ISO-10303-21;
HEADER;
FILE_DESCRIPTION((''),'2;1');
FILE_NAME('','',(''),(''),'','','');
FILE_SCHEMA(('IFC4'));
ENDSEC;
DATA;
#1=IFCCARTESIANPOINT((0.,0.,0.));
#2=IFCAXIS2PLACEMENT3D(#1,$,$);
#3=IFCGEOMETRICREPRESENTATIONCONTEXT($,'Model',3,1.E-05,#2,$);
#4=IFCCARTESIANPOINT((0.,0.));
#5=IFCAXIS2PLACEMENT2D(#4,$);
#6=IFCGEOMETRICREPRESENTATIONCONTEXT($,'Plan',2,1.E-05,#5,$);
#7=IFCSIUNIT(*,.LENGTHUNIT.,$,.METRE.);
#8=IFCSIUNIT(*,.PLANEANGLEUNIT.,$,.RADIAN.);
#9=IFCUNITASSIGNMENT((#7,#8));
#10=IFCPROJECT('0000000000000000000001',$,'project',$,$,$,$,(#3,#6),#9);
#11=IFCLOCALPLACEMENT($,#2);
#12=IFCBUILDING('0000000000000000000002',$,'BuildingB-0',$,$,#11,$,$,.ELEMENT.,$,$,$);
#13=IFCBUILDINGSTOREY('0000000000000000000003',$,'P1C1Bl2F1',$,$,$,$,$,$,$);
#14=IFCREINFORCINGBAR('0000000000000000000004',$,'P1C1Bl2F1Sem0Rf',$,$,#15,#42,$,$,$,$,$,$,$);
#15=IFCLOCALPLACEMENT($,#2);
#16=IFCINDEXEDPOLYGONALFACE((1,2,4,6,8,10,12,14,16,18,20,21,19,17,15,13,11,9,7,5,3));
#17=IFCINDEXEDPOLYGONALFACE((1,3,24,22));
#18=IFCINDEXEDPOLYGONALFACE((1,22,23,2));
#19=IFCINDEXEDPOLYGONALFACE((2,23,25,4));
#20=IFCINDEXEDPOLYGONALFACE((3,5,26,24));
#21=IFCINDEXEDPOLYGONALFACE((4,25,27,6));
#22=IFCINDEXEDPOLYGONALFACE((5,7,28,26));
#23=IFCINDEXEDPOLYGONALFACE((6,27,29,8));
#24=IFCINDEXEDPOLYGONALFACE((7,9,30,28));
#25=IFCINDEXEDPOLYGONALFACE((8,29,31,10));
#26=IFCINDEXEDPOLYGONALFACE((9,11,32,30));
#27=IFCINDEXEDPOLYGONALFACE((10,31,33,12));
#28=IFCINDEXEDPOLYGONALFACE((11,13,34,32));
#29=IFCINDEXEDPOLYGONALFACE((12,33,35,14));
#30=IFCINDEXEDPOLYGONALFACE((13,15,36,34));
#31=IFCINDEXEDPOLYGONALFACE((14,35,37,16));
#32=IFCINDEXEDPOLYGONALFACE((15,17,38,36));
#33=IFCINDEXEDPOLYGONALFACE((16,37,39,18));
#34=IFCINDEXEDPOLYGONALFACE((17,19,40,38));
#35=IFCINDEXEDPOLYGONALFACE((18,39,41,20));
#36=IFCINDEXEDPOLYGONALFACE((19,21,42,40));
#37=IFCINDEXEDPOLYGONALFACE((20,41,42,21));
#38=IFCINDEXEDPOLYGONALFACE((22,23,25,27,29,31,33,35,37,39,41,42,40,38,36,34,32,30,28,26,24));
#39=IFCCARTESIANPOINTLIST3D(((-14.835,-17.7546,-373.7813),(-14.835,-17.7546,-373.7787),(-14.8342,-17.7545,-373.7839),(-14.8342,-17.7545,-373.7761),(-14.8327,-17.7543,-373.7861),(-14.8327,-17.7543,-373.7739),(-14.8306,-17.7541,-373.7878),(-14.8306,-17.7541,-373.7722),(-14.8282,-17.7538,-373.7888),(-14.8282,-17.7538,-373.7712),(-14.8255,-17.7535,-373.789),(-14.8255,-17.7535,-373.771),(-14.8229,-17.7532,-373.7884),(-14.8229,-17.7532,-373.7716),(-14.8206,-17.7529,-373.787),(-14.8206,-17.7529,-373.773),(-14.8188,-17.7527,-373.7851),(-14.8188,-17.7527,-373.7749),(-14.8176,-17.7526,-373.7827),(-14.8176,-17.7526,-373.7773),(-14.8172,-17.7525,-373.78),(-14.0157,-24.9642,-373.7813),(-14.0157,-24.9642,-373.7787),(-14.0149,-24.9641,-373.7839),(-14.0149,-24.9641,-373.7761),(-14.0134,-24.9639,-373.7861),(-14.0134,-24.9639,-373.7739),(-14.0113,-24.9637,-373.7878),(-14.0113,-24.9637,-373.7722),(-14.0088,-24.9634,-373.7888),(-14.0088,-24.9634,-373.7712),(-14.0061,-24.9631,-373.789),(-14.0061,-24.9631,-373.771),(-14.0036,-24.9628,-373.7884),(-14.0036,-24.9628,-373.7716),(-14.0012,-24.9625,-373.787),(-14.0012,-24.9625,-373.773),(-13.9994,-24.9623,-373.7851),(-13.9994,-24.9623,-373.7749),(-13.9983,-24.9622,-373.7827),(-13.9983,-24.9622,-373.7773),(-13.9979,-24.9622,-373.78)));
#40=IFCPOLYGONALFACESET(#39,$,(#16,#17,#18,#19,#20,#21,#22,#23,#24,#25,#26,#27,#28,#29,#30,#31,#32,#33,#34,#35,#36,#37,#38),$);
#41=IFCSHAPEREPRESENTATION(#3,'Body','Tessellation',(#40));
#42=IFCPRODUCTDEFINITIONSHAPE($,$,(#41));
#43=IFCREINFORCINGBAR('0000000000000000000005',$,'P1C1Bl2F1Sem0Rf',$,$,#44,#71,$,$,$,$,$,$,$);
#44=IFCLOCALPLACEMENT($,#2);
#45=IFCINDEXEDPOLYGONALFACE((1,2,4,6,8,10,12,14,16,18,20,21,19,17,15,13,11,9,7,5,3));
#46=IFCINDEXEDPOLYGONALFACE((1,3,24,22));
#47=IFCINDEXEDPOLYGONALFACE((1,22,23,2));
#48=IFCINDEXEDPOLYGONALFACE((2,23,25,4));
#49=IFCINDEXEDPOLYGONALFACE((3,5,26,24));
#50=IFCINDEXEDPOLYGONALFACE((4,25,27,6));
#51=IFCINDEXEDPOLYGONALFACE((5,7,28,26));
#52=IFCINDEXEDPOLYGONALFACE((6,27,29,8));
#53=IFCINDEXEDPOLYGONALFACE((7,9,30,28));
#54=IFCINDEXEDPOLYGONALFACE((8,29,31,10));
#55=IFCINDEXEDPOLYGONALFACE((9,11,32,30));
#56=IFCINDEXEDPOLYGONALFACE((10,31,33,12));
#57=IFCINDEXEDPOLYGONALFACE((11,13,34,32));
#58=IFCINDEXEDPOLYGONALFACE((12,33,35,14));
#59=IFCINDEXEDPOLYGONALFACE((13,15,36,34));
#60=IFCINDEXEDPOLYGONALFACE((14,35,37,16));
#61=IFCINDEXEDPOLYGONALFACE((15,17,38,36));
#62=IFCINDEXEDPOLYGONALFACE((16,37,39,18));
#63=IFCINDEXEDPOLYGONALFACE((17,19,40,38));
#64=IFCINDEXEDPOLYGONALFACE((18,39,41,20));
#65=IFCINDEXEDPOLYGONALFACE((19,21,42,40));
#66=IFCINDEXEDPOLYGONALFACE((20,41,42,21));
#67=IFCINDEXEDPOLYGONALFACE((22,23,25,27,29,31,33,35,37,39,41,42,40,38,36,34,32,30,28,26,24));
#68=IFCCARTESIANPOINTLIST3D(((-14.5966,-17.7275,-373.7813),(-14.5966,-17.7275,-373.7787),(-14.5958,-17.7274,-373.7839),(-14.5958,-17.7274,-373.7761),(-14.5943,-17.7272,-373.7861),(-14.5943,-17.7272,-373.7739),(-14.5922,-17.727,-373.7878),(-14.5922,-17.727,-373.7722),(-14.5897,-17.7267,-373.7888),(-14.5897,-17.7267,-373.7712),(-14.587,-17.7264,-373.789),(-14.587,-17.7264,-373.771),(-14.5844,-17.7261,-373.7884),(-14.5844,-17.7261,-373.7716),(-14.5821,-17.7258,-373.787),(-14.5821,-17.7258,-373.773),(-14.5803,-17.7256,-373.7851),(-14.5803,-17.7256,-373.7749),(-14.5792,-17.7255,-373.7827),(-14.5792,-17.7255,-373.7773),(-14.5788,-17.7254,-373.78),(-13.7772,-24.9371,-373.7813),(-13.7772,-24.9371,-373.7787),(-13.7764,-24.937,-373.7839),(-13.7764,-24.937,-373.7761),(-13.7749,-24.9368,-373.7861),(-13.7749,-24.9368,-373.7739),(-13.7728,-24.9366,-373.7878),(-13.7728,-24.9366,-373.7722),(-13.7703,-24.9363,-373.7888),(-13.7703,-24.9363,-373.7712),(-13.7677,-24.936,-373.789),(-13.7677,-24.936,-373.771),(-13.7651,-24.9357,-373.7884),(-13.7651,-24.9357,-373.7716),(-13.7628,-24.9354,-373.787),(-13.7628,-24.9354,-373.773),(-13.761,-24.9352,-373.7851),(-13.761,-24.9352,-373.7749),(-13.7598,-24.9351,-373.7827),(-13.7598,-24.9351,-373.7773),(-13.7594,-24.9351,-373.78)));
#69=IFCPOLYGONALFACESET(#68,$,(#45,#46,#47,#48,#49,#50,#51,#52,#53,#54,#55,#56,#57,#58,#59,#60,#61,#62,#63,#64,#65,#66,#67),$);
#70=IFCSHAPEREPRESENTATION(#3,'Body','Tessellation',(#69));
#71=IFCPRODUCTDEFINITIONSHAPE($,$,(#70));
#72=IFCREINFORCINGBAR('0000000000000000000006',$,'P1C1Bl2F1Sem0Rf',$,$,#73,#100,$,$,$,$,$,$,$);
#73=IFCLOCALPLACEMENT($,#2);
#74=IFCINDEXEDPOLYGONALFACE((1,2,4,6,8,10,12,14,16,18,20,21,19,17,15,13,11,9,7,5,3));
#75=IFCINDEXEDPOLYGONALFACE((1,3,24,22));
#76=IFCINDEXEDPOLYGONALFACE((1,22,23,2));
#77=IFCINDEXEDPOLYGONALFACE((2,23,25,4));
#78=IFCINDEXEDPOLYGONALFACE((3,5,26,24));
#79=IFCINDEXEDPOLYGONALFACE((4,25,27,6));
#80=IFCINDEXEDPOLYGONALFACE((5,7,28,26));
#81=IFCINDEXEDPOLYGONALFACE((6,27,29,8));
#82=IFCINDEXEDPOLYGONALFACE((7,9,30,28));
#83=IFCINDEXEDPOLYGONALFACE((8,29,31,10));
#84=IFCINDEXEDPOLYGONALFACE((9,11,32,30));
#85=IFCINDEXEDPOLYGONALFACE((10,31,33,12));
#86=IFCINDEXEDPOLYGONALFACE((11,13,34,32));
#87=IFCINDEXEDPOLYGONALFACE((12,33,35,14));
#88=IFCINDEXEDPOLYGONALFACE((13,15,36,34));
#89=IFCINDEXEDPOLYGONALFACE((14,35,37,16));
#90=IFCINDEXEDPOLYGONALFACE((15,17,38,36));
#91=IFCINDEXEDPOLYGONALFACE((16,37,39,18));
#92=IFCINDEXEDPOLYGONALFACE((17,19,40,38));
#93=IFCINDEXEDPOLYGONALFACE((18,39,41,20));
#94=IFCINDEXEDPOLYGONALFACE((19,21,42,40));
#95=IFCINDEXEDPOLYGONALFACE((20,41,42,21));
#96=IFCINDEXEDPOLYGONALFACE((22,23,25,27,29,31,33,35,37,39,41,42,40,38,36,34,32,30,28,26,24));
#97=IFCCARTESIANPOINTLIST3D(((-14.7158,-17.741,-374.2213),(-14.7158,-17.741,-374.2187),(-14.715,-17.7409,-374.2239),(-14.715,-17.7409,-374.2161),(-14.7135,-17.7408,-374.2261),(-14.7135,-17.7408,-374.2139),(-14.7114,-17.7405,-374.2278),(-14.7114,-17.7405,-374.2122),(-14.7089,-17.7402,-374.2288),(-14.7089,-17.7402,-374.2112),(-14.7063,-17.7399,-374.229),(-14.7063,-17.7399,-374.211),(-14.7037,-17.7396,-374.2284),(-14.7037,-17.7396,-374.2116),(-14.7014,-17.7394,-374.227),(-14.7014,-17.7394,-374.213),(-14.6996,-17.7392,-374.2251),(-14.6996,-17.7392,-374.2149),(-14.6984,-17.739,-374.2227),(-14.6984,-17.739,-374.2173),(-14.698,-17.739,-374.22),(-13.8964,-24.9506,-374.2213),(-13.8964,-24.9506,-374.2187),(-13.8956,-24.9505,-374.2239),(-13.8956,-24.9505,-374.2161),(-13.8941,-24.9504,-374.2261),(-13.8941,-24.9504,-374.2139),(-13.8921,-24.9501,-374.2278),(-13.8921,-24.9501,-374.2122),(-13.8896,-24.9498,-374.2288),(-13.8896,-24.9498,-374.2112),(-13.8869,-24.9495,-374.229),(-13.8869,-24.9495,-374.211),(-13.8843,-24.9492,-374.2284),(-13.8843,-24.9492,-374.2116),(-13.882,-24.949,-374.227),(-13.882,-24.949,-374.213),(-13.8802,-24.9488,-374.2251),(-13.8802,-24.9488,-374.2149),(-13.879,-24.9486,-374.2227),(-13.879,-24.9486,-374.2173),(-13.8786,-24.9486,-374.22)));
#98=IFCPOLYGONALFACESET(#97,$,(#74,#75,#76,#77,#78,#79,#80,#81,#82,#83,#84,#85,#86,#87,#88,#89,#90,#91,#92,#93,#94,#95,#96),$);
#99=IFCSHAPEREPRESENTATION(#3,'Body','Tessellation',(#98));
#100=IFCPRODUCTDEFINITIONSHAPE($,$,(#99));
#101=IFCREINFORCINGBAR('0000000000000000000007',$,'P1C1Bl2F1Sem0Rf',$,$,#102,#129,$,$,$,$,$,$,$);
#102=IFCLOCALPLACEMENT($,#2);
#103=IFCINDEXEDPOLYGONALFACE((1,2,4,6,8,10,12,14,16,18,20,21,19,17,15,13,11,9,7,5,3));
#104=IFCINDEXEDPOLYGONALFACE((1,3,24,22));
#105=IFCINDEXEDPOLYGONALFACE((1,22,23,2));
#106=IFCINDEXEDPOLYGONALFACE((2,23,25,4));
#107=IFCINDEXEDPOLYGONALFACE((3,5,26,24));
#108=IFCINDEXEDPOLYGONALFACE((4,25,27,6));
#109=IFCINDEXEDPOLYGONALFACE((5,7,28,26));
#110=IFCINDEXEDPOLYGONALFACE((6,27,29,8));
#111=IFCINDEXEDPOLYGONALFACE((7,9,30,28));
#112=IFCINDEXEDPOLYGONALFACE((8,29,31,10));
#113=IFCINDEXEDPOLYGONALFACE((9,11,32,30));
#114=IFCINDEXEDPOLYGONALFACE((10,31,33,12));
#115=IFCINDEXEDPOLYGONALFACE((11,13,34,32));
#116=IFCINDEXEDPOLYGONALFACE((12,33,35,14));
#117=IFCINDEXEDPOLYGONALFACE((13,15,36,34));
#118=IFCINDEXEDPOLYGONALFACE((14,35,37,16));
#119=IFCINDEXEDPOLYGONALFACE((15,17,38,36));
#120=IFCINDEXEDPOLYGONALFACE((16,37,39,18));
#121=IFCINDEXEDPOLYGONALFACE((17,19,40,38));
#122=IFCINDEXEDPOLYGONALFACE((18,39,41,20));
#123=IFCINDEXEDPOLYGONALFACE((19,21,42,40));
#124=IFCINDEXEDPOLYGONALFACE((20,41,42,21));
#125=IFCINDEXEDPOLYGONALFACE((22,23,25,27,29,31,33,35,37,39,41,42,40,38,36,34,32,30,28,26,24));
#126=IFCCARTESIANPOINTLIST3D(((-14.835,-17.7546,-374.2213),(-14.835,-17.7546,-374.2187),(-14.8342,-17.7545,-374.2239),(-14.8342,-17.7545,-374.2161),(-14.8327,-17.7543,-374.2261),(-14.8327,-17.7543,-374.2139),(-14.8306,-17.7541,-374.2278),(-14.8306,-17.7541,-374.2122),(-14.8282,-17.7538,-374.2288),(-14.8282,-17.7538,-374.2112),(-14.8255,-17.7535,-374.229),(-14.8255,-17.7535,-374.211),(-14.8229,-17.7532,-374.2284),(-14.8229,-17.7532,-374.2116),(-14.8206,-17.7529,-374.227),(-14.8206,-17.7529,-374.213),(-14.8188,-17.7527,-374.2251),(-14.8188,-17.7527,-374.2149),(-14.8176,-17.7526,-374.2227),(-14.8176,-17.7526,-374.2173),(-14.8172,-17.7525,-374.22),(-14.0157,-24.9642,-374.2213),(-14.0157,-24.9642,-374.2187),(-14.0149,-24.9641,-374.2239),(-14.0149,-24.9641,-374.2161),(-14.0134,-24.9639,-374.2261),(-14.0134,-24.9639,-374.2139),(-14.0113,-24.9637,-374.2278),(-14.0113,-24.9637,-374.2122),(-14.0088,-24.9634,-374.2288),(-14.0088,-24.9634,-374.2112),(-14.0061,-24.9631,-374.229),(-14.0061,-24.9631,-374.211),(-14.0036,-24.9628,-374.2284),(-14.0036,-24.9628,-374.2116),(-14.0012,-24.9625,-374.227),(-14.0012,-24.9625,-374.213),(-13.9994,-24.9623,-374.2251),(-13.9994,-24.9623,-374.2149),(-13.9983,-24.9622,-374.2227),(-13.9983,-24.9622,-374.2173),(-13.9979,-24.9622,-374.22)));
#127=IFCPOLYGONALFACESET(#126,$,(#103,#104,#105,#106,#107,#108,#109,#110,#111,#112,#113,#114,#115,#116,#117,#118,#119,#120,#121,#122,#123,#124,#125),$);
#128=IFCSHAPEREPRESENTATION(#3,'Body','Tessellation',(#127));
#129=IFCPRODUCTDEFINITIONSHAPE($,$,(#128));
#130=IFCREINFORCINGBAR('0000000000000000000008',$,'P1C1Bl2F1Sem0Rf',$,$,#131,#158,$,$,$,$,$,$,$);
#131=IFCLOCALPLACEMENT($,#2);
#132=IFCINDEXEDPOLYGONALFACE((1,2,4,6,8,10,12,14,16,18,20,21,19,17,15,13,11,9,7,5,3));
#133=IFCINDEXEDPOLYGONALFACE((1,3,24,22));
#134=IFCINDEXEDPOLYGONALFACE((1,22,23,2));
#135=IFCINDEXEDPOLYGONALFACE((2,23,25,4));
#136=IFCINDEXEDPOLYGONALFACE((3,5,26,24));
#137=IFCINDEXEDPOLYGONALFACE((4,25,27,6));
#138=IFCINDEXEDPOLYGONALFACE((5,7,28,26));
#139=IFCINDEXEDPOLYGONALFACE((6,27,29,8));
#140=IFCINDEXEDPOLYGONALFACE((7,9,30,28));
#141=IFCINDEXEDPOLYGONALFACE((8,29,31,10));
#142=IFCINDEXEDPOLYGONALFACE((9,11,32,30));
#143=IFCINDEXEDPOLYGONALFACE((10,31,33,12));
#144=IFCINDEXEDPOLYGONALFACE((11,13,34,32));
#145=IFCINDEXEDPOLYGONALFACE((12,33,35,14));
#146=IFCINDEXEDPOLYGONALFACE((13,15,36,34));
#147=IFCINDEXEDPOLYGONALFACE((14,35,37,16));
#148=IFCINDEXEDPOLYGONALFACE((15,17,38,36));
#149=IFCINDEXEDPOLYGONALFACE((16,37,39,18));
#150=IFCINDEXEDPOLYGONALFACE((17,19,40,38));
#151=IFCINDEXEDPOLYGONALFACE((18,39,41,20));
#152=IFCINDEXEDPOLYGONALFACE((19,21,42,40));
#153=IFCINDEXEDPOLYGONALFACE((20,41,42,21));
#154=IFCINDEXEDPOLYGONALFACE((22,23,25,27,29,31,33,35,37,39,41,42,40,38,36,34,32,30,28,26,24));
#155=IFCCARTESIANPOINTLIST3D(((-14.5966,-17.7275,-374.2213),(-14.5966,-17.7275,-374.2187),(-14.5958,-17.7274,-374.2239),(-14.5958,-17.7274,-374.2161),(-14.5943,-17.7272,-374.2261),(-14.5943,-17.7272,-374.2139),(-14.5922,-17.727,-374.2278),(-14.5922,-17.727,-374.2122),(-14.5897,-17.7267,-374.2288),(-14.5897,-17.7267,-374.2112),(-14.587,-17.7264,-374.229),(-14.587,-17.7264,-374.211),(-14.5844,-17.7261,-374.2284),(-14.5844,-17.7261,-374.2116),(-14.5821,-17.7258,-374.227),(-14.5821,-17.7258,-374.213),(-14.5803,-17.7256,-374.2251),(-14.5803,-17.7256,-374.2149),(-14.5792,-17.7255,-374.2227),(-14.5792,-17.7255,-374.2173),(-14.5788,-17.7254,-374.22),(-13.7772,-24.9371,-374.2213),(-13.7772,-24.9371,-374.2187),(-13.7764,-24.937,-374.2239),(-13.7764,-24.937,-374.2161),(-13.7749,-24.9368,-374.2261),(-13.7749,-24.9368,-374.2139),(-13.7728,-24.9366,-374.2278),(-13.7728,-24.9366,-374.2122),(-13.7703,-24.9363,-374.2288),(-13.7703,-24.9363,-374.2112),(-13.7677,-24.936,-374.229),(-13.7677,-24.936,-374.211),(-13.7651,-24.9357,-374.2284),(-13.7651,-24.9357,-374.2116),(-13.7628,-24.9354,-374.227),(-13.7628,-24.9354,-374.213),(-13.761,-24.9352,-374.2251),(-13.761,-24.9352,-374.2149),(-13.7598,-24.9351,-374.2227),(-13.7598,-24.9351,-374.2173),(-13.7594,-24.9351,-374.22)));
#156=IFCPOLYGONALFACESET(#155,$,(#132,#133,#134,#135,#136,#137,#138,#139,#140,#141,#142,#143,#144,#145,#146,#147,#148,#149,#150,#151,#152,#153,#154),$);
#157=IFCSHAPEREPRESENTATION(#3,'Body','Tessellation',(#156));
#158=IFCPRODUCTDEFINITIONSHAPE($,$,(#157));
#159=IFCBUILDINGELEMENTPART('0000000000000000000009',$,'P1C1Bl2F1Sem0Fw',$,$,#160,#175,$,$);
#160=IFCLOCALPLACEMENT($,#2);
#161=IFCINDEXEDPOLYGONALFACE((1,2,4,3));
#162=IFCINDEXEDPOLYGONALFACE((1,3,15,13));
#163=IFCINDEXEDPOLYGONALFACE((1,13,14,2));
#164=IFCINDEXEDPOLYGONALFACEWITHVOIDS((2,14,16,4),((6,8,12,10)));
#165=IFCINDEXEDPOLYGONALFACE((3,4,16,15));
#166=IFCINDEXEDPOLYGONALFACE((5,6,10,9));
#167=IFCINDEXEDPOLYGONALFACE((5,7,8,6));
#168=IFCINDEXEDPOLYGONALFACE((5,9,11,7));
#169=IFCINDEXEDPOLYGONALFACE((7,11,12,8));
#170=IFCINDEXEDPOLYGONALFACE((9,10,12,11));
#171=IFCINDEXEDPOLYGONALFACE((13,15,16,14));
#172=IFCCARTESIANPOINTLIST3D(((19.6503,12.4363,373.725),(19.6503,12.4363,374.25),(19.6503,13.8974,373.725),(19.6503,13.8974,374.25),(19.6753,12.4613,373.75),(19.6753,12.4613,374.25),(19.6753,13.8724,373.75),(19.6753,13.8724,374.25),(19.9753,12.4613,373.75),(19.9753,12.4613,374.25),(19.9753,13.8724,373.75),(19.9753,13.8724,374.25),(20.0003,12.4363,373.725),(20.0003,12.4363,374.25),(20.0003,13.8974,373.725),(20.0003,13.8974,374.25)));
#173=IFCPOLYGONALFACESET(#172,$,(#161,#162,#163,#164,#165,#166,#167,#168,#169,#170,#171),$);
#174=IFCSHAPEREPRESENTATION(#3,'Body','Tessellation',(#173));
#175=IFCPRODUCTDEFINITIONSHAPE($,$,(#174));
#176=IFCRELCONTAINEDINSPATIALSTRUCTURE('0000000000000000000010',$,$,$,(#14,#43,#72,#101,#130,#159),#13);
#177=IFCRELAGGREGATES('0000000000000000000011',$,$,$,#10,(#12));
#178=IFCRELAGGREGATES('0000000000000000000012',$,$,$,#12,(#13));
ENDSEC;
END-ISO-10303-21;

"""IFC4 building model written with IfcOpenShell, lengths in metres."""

from ifc_helpers import new_model, entity, si_unit, origin, origin_2d, place, context, project, spatial, polyline, outline, extrude, element, save


model = new_model("IFC4")

# Units and contexts
model_context = context("Model", 3, precision=1e-05, world=origin())
plan_context = context("Plan", 2, precision=1e-05, world=origin_2d())
ifc_project = project(units=[si_unit("LENGTHUNIT", "METRE"), si_unit("PLANEANGLEUNIT", "RADIAN")], contexts=[model_context, plan_context])

# Building, storey
building_placement = place(None, origin())
building = spatial("IfcBuilding", under=ifc_project, at=building_placement, Name="BuildingB-0", CompositionType="ELEMENT")
storey = spatial("IfcBuildingStorey", under=building, Name="P1C1Bl2F1")

# Reinforcing bars
element("IfcReinforcingBar", 1, inside=storey, Name="P1C1Bl2F1Sem0Rf", context=model_context, shape_type="SweptSolid", body=[
    entity("IfcSurfaceCurveSweptAreaSolid", entity("IfcCircleProfileDef", "AREA", None, None, 0.009), None, entity("IfcPolyline", [entity("IfcCartesianPoint", [14.8262, 17.7536, 373.78]), entity("IfcCartesianPoint", [14.0068, 24.9632, 373.78])]), None, None, entity("IfcPlane", entity("IfcAxis2Placement3D", entity("IfcCartesianPoint", [14.8262, 17.7536, 373.78]), entity("IfcDirection", [0.0, 0.0, 1.0]), entity("IfcDirection", [1.0, 0.0, 0.0])))),
])
element("IfcReinforcingBar", 2, inside=storey, Name="P1C1Bl2F1Sem0Rf", context=model_context, shape_type="SweptSolid", body=[
    entity("IfcSurfaceCurveSweptAreaSolid", entity("IfcCircleProfileDef", "AREA", None, None, 0.009), None, entity("IfcPolyline", [entity("IfcCartesianPoint", [14.5877, 17.7265, 373.78]), entity("IfcCartesianPoint", [13.7684, 24.9361, 373.78])]), None, None, entity("IfcPlane", entity("IfcAxis2Placement3D", entity("IfcCartesianPoint", [14.5877, 17.7265, 373.78]), entity("IfcDirection", [0.0, 0.0, 1.0]), entity("IfcDirection", [1.0, 0.0, 0.0])))),
])
element("IfcReinforcingBar", 3, inside=storey, Name="P1C1Bl2F1Sem0Rf", context=model_context, shape_type="SweptSolid", body=[
    entity("IfcSurfaceCurveSweptAreaSolid", entity("IfcCircleProfileDef", "AREA", None, None, 0.009), None, entity("IfcPolyline", [entity("IfcCartesianPoint", [14.7069, 17.74, 374.22]), entity("IfcCartesianPoint", [13.8876, 24.9496, 374.22])]), None, None, entity("IfcPlane", entity("IfcAxis2Placement3D", entity("IfcCartesianPoint", [14.7069, 17.74, 374.22]), entity("IfcDirection", [0.0, 0.0, 1.0]), entity("IfcDirection", [1.0, 0.0, 0.0])))),
])
element("IfcReinforcingBar", 4, inside=storey, Name="P1C1Bl2F1Sem0Rf", context=model_context, shape_type="SweptSolid", body=[
    entity("IfcSurfaceCurveSweptAreaSolid", entity("IfcCircleProfileDef", "AREA", None, None, 0.009), None, entity("IfcPolyline", [entity("IfcCartesianPoint", [14.8262, 17.7536, 374.22]), entity("IfcCartesianPoint", [14.0068, 24.9632, 374.22])]), None, None, entity("IfcPlane", entity("IfcAxis2Placement3D", entity("IfcCartesianPoint", [14.8262, 17.7536, 374.22]), entity("IfcDirection", [0.0, 0.0, 1.0]), entity("IfcDirection", [1.0, 0.0, 0.0])))),
])
element("IfcReinforcingBar", 5, inside=storey, Name="P1C1Bl2F1Sem0Rf", context=model_context, shape_type="SweptSolid", body=[
    entity("IfcSurfaceCurveSweptAreaSolid", entity("IfcCircleProfileDef", "AREA", None, None, 0.009), None, entity("IfcPolyline", [entity("IfcCartesianPoint", [14.5877, 17.7265, 374.22]), entity("IfcCartesianPoint", [13.7684, 24.9361, 374.22])]), None, None, entity("IfcPlane", entity("IfcAxis2Placement3D", entity("IfcCartesianPoint", [14.5877, 17.7265, 374.22]), entity("IfcDirection", [0.0, 0.0, 1.0]), entity("IfcDirection", [1.0, 0.0, 0.0])))),
])

# Building element part, opening
building_element_part_1 = element("IfcBuildingElementPart", 6, inside=storey, Name="P1C1Bl2F1Sem0Fw", context=model_context, shape_type="SweptSolid", body=[
    extrude(outline(polyline([(19.6503, 12.4363, 373.725), (20.0003, 12.4363, 373.725), (20.0003, 13.8974, 373.725), (19.6503, 13.8974, 373.725), (19.6503, 12.4363, 373.725)])), None, (0.0, 0.0, 1.0), 0.525),
])
element("IfcOpeningElement", 7, inside=storey, cuts=building_element_part_1, context=model_context, shape_type="SweptSolid", body=[
    extrude(outline(polyline([(19.6753, 12.4613, 373.75), (19.9753, 12.4613, 373.75), (19.9753, 13.8724, 373.75), (19.6753, 13.8724, 373.75), (19.6753, 12.4613, 373.75)])), None, (0.0, 0.0, 1.0), 0.5),
])

save(model, "model.ifc")
